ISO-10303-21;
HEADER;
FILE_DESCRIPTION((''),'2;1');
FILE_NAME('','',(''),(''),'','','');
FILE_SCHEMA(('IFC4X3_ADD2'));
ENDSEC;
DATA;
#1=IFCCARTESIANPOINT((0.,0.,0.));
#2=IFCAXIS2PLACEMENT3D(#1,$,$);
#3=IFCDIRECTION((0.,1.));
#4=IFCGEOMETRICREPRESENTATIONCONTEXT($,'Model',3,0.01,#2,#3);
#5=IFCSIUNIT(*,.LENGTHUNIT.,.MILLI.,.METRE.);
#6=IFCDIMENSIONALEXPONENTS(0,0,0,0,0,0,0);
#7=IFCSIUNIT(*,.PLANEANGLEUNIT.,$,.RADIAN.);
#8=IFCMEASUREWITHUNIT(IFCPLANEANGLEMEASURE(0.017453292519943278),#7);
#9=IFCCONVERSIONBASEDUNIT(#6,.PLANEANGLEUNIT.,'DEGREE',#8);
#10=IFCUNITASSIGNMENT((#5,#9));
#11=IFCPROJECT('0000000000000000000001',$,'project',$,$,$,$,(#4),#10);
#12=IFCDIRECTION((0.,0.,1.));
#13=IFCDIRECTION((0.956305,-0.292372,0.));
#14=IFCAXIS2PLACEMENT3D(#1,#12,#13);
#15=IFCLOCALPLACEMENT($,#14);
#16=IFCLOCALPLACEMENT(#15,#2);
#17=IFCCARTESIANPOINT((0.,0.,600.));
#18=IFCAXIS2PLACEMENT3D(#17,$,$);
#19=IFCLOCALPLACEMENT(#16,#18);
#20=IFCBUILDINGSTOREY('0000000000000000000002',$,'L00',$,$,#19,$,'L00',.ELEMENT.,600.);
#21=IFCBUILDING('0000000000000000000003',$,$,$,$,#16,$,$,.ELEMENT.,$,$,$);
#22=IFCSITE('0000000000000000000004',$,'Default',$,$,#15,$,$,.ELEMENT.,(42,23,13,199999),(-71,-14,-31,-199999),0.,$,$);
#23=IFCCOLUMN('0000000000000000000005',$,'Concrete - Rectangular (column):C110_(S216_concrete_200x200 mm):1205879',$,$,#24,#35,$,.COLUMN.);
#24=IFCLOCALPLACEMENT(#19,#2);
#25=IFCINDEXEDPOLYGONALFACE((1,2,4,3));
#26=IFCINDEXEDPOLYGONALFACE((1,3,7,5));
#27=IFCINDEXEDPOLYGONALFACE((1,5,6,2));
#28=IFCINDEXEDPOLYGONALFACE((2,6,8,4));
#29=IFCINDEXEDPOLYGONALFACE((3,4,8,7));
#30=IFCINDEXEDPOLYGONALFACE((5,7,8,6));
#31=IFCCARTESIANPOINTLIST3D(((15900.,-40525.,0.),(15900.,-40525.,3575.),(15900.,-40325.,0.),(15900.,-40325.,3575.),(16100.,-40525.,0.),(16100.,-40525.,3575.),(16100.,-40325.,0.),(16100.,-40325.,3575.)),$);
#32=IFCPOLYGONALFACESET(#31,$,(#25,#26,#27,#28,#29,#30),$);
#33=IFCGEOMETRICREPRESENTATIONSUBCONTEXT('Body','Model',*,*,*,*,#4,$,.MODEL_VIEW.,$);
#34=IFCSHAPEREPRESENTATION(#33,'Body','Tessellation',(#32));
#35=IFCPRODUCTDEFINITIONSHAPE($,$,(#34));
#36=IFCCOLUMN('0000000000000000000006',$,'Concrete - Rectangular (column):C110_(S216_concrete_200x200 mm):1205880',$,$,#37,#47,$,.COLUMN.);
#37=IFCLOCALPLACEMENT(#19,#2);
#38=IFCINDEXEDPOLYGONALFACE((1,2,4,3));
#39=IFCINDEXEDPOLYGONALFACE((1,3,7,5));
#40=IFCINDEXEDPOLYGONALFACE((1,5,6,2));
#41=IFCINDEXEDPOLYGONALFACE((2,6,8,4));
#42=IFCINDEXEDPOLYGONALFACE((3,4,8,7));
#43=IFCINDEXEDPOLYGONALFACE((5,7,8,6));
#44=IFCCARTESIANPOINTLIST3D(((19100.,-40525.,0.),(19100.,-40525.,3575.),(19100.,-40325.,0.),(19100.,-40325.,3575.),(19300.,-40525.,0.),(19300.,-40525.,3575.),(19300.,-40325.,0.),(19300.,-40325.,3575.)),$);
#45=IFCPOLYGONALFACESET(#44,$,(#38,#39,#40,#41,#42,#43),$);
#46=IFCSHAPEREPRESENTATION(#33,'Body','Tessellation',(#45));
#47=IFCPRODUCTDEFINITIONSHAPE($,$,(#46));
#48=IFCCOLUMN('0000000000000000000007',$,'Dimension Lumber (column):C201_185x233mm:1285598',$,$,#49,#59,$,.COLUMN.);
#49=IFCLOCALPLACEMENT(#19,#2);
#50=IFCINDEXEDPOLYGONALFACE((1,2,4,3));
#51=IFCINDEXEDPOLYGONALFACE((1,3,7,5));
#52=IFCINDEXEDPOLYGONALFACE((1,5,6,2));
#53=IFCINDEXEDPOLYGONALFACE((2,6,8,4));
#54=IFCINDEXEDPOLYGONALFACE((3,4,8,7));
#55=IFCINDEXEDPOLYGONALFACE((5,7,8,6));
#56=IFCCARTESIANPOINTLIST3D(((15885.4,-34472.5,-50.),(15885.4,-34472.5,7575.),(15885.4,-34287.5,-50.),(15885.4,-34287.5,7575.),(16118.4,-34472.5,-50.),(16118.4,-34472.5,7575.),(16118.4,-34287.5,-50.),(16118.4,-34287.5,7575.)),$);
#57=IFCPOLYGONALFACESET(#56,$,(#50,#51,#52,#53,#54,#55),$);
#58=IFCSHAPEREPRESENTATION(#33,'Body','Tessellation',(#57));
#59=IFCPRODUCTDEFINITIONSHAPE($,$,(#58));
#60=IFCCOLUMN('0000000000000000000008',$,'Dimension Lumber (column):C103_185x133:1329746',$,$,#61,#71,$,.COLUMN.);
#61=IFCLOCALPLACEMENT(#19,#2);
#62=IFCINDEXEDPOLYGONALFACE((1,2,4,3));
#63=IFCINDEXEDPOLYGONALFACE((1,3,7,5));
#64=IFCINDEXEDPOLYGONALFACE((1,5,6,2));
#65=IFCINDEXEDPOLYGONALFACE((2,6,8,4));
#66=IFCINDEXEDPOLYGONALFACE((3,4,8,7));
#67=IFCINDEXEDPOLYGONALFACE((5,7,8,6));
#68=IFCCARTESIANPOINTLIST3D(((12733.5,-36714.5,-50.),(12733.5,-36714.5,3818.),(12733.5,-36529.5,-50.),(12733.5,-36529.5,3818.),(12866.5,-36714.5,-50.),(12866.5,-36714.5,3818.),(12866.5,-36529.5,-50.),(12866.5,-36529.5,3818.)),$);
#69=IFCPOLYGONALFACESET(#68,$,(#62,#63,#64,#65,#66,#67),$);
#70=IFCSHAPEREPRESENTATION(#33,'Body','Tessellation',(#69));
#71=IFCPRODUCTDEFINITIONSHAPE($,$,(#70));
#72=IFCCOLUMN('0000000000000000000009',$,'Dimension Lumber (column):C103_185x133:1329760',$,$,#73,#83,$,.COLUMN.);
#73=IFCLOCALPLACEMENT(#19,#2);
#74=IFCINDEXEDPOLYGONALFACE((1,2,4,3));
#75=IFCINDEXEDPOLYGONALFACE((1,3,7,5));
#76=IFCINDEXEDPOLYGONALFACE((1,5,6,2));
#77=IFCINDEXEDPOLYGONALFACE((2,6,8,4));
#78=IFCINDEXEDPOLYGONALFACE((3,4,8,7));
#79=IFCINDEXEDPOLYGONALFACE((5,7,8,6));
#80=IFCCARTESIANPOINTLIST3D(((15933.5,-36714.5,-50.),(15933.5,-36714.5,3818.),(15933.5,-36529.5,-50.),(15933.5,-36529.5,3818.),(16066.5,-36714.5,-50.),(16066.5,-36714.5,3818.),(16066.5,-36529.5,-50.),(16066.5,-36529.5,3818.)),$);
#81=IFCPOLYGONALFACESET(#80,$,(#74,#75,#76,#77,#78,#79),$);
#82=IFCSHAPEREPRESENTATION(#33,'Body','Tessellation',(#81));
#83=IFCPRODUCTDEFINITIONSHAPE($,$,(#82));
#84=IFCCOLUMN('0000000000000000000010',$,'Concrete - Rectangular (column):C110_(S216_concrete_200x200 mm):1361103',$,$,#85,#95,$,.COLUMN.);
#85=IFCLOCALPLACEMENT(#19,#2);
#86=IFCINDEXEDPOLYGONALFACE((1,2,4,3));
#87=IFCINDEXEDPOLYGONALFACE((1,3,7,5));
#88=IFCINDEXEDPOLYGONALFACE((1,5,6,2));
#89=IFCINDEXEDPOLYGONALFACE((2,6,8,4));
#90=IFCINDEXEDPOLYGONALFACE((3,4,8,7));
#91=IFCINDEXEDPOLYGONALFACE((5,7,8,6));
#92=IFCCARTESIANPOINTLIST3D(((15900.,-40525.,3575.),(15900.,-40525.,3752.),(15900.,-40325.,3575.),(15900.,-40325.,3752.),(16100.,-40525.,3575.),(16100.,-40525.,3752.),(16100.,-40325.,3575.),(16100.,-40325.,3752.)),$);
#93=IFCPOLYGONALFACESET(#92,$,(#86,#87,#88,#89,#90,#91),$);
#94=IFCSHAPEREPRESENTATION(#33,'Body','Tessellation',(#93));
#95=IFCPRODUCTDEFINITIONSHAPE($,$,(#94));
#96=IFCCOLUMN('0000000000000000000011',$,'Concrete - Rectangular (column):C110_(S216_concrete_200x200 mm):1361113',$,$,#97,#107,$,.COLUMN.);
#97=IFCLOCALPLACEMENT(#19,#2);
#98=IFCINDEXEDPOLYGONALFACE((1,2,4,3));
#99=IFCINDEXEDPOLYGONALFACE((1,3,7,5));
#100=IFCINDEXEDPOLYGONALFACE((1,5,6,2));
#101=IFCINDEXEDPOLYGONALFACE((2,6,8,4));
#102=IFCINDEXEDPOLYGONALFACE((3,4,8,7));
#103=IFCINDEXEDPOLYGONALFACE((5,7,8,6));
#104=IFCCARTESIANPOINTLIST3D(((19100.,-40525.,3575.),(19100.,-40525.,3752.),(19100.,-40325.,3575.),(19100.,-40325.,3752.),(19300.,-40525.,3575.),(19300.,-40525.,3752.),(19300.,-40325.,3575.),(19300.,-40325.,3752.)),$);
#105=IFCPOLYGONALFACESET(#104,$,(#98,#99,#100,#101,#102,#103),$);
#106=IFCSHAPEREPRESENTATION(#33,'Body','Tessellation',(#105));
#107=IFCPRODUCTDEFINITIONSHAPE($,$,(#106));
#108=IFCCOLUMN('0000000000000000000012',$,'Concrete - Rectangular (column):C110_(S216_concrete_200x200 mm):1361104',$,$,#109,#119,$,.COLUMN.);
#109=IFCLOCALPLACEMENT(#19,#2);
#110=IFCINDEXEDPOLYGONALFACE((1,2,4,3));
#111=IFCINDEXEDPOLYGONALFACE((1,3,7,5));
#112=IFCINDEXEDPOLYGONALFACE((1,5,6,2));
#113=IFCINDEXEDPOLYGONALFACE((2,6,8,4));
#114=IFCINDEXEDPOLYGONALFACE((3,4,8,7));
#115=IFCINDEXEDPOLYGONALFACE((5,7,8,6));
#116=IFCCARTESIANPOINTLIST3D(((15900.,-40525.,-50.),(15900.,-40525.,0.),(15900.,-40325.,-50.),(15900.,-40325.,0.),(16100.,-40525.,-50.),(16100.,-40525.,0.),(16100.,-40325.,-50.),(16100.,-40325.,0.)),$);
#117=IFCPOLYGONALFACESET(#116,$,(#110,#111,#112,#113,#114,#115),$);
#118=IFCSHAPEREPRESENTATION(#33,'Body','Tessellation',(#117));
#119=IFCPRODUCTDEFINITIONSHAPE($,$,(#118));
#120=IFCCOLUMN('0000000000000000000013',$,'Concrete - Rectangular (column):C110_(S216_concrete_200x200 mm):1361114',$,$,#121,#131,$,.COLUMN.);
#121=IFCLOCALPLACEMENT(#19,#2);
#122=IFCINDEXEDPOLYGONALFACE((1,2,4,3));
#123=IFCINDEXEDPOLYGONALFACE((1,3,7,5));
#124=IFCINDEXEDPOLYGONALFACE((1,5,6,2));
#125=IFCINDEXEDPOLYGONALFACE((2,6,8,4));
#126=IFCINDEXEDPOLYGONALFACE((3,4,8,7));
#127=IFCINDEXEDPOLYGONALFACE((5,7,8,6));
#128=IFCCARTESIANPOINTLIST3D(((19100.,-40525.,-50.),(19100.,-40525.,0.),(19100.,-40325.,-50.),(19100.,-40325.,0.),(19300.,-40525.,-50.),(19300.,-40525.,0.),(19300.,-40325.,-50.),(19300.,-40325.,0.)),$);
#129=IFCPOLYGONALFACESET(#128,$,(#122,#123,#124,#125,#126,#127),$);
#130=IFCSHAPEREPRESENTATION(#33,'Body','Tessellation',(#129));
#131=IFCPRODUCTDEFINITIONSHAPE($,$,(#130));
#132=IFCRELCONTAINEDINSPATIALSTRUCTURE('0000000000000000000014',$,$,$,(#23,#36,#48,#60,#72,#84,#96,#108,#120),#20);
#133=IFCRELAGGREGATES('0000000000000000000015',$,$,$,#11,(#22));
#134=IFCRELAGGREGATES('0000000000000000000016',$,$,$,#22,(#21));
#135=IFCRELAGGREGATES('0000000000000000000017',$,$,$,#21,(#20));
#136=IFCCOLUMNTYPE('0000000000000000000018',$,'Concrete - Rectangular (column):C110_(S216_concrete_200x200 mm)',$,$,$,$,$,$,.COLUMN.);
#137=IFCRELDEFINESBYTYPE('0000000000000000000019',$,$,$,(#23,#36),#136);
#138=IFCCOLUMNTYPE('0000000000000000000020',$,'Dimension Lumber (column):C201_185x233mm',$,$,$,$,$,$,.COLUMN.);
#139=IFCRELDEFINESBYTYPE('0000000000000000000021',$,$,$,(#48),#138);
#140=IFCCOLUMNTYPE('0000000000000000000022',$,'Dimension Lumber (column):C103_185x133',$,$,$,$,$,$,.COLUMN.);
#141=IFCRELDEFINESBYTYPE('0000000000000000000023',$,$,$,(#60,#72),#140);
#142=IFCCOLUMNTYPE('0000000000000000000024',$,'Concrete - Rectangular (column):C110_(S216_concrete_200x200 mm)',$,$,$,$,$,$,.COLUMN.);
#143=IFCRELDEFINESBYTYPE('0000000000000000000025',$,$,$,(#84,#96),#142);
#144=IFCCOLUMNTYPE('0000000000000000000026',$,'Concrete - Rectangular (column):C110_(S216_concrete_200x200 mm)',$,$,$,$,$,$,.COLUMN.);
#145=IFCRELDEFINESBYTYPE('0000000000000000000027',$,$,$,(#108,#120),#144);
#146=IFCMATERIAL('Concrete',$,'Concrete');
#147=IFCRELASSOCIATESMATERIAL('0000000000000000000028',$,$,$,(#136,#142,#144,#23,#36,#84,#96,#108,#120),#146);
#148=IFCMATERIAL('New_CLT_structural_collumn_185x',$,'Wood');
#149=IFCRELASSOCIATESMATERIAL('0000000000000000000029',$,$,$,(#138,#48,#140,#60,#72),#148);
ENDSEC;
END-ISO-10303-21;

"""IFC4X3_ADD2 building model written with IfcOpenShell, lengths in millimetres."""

from ifc_helpers import new_model, entity, si_unit, converted_unit, direction, frame, origin, origin_2d_with_axis, place, context, subcontext, project, spatial, rectangle, extrude, source, transform, mapped, material, material_profile, profile_set, profile_usage, type_object, type_shapes, element, save


model = new_model("IFC4X3_ADD2")

# Units and contexts
model_context = context("Model", 3, precision=0.01, world=origin(), true_north=direction((0.0, 1.0)))
body_context = subcontext(model_context, "Body", "Model", "MODEL_VIEW")
ifc_project = project(units=[si_unit("LENGTHUNIT", "METRE", prefix="MILLI"), converted_unit("PLANEANGLEUNIT", "DEGREE", entity("IfcPlaneAngleMeasure", 0.017453292519943278), si_unit("PLANEANGLEUNIT", "RADIAN"), dimensions=[0, 0, 0, 0, 0, 0, 0])], contexts=[model_context])

# Site, building, storey
site_placement = place(None, frame((0.0, 0.0, 0.0), z_axis=(0.0, 0.0, 1.0), x_axis=(0.956305, -0.292372, 0.0)))
site = spatial("IfcSite", under=ifc_project, at=site_placement, Name="Default", CompositionType="ELEMENT", RefLatitude=(42, 23, 13, 199999), RefLongitude=(-71, -14, -31, -199999), RefElevation=0.0)
building_placement = place(site_placement, origin())
building = spatial("IfcBuilding", under=site, at=building_placement, CompositionType="ELEMENT")
storey_placement = place(building_placement, frame((0.0, 0.0, 600.0)))
storey = spatial("IfcBuildingStorey", under=building, at=storey_placement, Name="L00", LongName="L00", CompositionType="ELEMENT", Elevation=600.0)

# Columns
ifc_material_1 = material(Name="Concrete", Category="Concrete")
ifc_material_profile_1 = material_profile(ifc_material_1, rectangle(XDim=200.0, YDim=200.0, at=origin_2d_with_axis()), Name="C110_(S216_concrete_200x200 mm)")
ifc_profile_set_1 = profile_set([ifc_material_profile_1], Name="C110_(S216_concrete_200x200 mm)")
ifc_profile_usage_1 = profile_usage(ifc_profile_set_1)
column_type_1 = type_object("IfcColumnType", Name="Concrete - Rectangular (column):C110_(S216_concrete_200x200 mm)", PredefinedType="COLUMN", material=ifc_profile_set_1)
shared_shape_1 = source(origin(), body_context, "Body", "SweptSolid", [
    extrude(rectangle(XDim=200.0, YDim=200.0, at=origin_2d_with_axis()), frame((0.0, 0.0, 600.0), z_axis=(0.0, 0.0, 1.0), x_axis=(-1.0, 0.0, 0.0)), (0.0, 0.0, 1.0), 3575.0),
])
type_shapes(column_type_1, [shared_shape_1])
for number, where, name in (
    (1, (16000.0, -40425.0, -600.0), "Concrete - Rectangular (column):C110_(S216_concrete_200x200 mm):1205879"),
    (2, (19200.0, -40425.0, -600.0), "Concrete - Rectangular (column):C110_(S216_concrete_200x200 mm):1205880"),
):
    element("IfcColumn", number, at=place(storey_placement, frame(where)), inside=storey, type_object=column_type_1, material=ifc_profile_usage_1, Name=name, PredefinedType="COLUMN", context=body_context, shape_type="MappedRepresentation", body=[
        mapped(shared_shape_1, transform((0.0, 0.0, 0.0), scale=1.0)),
    ])
ifc_material_2 = material(Name="New_CLT_structural_collumn_185x", Category="Wood")
ifc_material_profile_2 = material_profile(ifc_material_2, rectangle(XDim=185.0, YDim=233.0, at=origin_2d_with_axis()), Name="C201_185x233mm")
ifc_profile_set_2 = profile_set([ifc_material_profile_2], Name="C201_185x233mm")
ifc_profile_usage_2 = profile_usage(ifc_profile_set_2)
column_type_2 = type_object("IfcColumnType", Name="Dimension Lumber (column):C201_185x233mm", PredefinedType="COLUMN", material=ifc_profile_set_2)
shared_shape_2 = source(origin(), body_context, "Body", "SweptSolid", [
    extrude(rectangle(XDim=185.0, YDim=233.0, at=origin_2d_with_axis()), frame((0.0, 0.0, 550.0), z_axis=(0.0, 0.0, 1.0), x_axis=(-1.0, 0.0, 0.0)), (0.0, 0.0, 1.0), 7625.0),
])
type_shapes(column_type_2, [shared_shape_2])
column_placement = place(storey_placement, frame((16001.9, -34380.0, -600.0), z_axis=(0.0, 0.0, 1.0), x_axis=(0.0, 1.0, 0.0)))
element("IfcColumn", 3, at=column_placement, inside=storey, type_object=column_type_2, material=ifc_profile_usage_2, Name="Dimension Lumber (column):C201_185x233mm:1285598", PredefinedType="COLUMN", context=body_context, shape_type="MappedRepresentation", body=[
    mapped(shared_shape_2, transform((0.0, 0.0, 0.0), scale=1.0)),
])
ifc_material_profile_3 = material_profile(ifc_material_2, rectangle(XDim=185.0, YDim=133.0, at=origin_2d_with_axis()), Name="C103_185x133")
ifc_profile_set_3 = profile_set([ifc_material_profile_3], Name="C103_185x133")
ifc_profile_usage_3 = profile_usage(ifc_profile_set_3)
column_type_3 = type_object("IfcColumnType", Name="Dimension Lumber (column):C103_185x133", PredefinedType="COLUMN", material=ifc_profile_set_3)
shared_shape_3 = source(origin(), body_context, "Body", "SweptSolid", [
    extrude(rectangle(XDim=185.0, YDim=133.0, at=origin_2d_with_axis()), frame((0.0, 0.0, 550.0), z_axis=(0.0, 0.0, 1.0), x_axis=(-1.0, 0.0, 0.0)), (0.0, 0.0, 1.0), 3868.0),
])
type_shapes(column_type_3, [shared_shape_3])
for number, where, z_axis, x_axis, name in (
    (4, (12800.0, -36622.0, -600.0), (0.0, 0.0, 1.0), (0.0, -1.0, 0.0), "Dimension Lumber (column):C103_185x133:1329746"),
    (5, (16000.0, -36622.0, -600.0), (0.0, 0.0, 1.0), (0.0, -1.0, 0.0), "Dimension Lumber (column):C103_185x133:1329760"),
):
    element("IfcColumn", number, at=place(storey_placement, frame(where, z_axis=z_axis, x_axis=x_axis)), inside=storey, type_object=column_type_3, material=ifc_profile_usage_3, Name=name, PredefinedType="COLUMN", context=body_context, shape_type="MappedRepresentation", body=[
        mapped(shared_shape_3, transform((0.0, 0.0, 0.0), scale=1.0)),
    ])
column_type_4 = type_object("IfcColumnType", Name="Concrete - Rectangular (column):C110_(S216_concrete_200x200 mm)", PredefinedType="COLUMN", material=ifc_profile_set_1)
shared_shape_4 = source(origin(), body_context, "Body", "SweptSolid", [
    extrude(rectangle(XDim=200.0, YDim=200.0, at=origin_2d_with_axis()), frame((0.0, 0.0, 4175.0), z_axis=(0.0, 0.0, 1.0), x_axis=(-1.0, 0.0, 0.0)), (0.0, 0.0, 1.0), 177.0),
])
type_shapes(column_type_4, [shared_shape_4])
for number, where, name in (
    (6, (16000.0, -40425.0, -600.0), "Concrete - Rectangular (column):C110_(S216_concrete_200x200 mm):1361103"),
    (7, (19200.0, -40425.0, -600.0), "Concrete - Rectangular (column):C110_(S216_concrete_200x200 mm):1361113"),
):
    element("IfcColumn", number, at=place(storey_placement, frame(where)), inside=storey, type_object=column_type_4, material=ifc_profile_usage_1, Name=name, PredefinedType="COLUMN", context=body_context, shape_type="MappedRepresentation", body=[
        mapped(shared_shape_4, transform((0.0, 0.0, 0.0), scale=1.0)),
    ])
column_type_5 = type_object("IfcColumnType", Name="Concrete - Rectangular (column):C110_(S216_concrete_200x200 mm)", PredefinedType="COLUMN", material=ifc_profile_set_1)
shared_shape_5 = source(origin(), body_context, "Body", "SweptSolid", [
    extrude(rectangle(XDim=200.0, YDim=200.0, at=origin_2d_with_axis()), frame((0.0, 0.0, 550.0), z_axis=(0.0, 0.0, 1.0), x_axis=(-1.0, 0.0, 0.0)), (0.0, 0.0, 1.0), 50.0),
])
type_shapes(column_type_5, [shared_shape_5])
for number, where, name in (
    (8, (16000.0, -40425.0, -600.0), "Concrete - Rectangular (column):C110_(S216_concrete_200x200 mm):1361104"),
    (9, (19200.0, -40425.0, -600.0), "Concrete - Rectangular (column):C110_(S216_concrete_200x200 mm):1361114"),
):
    element("IfcColumn", number, at=place(storey_placement, frame(where)), inside=storey, type_object=column_type_5, material=ifc_profile_usage_1, Name=name, PredefinedType="COLUMN", context=body_context, shape_type="MappedRepresentation", body=[
        mapped(shared_shape_5, transform((0.0, 0.0, 0.0), scale=1.0)),
    ])

save(model, "model.ifc")
